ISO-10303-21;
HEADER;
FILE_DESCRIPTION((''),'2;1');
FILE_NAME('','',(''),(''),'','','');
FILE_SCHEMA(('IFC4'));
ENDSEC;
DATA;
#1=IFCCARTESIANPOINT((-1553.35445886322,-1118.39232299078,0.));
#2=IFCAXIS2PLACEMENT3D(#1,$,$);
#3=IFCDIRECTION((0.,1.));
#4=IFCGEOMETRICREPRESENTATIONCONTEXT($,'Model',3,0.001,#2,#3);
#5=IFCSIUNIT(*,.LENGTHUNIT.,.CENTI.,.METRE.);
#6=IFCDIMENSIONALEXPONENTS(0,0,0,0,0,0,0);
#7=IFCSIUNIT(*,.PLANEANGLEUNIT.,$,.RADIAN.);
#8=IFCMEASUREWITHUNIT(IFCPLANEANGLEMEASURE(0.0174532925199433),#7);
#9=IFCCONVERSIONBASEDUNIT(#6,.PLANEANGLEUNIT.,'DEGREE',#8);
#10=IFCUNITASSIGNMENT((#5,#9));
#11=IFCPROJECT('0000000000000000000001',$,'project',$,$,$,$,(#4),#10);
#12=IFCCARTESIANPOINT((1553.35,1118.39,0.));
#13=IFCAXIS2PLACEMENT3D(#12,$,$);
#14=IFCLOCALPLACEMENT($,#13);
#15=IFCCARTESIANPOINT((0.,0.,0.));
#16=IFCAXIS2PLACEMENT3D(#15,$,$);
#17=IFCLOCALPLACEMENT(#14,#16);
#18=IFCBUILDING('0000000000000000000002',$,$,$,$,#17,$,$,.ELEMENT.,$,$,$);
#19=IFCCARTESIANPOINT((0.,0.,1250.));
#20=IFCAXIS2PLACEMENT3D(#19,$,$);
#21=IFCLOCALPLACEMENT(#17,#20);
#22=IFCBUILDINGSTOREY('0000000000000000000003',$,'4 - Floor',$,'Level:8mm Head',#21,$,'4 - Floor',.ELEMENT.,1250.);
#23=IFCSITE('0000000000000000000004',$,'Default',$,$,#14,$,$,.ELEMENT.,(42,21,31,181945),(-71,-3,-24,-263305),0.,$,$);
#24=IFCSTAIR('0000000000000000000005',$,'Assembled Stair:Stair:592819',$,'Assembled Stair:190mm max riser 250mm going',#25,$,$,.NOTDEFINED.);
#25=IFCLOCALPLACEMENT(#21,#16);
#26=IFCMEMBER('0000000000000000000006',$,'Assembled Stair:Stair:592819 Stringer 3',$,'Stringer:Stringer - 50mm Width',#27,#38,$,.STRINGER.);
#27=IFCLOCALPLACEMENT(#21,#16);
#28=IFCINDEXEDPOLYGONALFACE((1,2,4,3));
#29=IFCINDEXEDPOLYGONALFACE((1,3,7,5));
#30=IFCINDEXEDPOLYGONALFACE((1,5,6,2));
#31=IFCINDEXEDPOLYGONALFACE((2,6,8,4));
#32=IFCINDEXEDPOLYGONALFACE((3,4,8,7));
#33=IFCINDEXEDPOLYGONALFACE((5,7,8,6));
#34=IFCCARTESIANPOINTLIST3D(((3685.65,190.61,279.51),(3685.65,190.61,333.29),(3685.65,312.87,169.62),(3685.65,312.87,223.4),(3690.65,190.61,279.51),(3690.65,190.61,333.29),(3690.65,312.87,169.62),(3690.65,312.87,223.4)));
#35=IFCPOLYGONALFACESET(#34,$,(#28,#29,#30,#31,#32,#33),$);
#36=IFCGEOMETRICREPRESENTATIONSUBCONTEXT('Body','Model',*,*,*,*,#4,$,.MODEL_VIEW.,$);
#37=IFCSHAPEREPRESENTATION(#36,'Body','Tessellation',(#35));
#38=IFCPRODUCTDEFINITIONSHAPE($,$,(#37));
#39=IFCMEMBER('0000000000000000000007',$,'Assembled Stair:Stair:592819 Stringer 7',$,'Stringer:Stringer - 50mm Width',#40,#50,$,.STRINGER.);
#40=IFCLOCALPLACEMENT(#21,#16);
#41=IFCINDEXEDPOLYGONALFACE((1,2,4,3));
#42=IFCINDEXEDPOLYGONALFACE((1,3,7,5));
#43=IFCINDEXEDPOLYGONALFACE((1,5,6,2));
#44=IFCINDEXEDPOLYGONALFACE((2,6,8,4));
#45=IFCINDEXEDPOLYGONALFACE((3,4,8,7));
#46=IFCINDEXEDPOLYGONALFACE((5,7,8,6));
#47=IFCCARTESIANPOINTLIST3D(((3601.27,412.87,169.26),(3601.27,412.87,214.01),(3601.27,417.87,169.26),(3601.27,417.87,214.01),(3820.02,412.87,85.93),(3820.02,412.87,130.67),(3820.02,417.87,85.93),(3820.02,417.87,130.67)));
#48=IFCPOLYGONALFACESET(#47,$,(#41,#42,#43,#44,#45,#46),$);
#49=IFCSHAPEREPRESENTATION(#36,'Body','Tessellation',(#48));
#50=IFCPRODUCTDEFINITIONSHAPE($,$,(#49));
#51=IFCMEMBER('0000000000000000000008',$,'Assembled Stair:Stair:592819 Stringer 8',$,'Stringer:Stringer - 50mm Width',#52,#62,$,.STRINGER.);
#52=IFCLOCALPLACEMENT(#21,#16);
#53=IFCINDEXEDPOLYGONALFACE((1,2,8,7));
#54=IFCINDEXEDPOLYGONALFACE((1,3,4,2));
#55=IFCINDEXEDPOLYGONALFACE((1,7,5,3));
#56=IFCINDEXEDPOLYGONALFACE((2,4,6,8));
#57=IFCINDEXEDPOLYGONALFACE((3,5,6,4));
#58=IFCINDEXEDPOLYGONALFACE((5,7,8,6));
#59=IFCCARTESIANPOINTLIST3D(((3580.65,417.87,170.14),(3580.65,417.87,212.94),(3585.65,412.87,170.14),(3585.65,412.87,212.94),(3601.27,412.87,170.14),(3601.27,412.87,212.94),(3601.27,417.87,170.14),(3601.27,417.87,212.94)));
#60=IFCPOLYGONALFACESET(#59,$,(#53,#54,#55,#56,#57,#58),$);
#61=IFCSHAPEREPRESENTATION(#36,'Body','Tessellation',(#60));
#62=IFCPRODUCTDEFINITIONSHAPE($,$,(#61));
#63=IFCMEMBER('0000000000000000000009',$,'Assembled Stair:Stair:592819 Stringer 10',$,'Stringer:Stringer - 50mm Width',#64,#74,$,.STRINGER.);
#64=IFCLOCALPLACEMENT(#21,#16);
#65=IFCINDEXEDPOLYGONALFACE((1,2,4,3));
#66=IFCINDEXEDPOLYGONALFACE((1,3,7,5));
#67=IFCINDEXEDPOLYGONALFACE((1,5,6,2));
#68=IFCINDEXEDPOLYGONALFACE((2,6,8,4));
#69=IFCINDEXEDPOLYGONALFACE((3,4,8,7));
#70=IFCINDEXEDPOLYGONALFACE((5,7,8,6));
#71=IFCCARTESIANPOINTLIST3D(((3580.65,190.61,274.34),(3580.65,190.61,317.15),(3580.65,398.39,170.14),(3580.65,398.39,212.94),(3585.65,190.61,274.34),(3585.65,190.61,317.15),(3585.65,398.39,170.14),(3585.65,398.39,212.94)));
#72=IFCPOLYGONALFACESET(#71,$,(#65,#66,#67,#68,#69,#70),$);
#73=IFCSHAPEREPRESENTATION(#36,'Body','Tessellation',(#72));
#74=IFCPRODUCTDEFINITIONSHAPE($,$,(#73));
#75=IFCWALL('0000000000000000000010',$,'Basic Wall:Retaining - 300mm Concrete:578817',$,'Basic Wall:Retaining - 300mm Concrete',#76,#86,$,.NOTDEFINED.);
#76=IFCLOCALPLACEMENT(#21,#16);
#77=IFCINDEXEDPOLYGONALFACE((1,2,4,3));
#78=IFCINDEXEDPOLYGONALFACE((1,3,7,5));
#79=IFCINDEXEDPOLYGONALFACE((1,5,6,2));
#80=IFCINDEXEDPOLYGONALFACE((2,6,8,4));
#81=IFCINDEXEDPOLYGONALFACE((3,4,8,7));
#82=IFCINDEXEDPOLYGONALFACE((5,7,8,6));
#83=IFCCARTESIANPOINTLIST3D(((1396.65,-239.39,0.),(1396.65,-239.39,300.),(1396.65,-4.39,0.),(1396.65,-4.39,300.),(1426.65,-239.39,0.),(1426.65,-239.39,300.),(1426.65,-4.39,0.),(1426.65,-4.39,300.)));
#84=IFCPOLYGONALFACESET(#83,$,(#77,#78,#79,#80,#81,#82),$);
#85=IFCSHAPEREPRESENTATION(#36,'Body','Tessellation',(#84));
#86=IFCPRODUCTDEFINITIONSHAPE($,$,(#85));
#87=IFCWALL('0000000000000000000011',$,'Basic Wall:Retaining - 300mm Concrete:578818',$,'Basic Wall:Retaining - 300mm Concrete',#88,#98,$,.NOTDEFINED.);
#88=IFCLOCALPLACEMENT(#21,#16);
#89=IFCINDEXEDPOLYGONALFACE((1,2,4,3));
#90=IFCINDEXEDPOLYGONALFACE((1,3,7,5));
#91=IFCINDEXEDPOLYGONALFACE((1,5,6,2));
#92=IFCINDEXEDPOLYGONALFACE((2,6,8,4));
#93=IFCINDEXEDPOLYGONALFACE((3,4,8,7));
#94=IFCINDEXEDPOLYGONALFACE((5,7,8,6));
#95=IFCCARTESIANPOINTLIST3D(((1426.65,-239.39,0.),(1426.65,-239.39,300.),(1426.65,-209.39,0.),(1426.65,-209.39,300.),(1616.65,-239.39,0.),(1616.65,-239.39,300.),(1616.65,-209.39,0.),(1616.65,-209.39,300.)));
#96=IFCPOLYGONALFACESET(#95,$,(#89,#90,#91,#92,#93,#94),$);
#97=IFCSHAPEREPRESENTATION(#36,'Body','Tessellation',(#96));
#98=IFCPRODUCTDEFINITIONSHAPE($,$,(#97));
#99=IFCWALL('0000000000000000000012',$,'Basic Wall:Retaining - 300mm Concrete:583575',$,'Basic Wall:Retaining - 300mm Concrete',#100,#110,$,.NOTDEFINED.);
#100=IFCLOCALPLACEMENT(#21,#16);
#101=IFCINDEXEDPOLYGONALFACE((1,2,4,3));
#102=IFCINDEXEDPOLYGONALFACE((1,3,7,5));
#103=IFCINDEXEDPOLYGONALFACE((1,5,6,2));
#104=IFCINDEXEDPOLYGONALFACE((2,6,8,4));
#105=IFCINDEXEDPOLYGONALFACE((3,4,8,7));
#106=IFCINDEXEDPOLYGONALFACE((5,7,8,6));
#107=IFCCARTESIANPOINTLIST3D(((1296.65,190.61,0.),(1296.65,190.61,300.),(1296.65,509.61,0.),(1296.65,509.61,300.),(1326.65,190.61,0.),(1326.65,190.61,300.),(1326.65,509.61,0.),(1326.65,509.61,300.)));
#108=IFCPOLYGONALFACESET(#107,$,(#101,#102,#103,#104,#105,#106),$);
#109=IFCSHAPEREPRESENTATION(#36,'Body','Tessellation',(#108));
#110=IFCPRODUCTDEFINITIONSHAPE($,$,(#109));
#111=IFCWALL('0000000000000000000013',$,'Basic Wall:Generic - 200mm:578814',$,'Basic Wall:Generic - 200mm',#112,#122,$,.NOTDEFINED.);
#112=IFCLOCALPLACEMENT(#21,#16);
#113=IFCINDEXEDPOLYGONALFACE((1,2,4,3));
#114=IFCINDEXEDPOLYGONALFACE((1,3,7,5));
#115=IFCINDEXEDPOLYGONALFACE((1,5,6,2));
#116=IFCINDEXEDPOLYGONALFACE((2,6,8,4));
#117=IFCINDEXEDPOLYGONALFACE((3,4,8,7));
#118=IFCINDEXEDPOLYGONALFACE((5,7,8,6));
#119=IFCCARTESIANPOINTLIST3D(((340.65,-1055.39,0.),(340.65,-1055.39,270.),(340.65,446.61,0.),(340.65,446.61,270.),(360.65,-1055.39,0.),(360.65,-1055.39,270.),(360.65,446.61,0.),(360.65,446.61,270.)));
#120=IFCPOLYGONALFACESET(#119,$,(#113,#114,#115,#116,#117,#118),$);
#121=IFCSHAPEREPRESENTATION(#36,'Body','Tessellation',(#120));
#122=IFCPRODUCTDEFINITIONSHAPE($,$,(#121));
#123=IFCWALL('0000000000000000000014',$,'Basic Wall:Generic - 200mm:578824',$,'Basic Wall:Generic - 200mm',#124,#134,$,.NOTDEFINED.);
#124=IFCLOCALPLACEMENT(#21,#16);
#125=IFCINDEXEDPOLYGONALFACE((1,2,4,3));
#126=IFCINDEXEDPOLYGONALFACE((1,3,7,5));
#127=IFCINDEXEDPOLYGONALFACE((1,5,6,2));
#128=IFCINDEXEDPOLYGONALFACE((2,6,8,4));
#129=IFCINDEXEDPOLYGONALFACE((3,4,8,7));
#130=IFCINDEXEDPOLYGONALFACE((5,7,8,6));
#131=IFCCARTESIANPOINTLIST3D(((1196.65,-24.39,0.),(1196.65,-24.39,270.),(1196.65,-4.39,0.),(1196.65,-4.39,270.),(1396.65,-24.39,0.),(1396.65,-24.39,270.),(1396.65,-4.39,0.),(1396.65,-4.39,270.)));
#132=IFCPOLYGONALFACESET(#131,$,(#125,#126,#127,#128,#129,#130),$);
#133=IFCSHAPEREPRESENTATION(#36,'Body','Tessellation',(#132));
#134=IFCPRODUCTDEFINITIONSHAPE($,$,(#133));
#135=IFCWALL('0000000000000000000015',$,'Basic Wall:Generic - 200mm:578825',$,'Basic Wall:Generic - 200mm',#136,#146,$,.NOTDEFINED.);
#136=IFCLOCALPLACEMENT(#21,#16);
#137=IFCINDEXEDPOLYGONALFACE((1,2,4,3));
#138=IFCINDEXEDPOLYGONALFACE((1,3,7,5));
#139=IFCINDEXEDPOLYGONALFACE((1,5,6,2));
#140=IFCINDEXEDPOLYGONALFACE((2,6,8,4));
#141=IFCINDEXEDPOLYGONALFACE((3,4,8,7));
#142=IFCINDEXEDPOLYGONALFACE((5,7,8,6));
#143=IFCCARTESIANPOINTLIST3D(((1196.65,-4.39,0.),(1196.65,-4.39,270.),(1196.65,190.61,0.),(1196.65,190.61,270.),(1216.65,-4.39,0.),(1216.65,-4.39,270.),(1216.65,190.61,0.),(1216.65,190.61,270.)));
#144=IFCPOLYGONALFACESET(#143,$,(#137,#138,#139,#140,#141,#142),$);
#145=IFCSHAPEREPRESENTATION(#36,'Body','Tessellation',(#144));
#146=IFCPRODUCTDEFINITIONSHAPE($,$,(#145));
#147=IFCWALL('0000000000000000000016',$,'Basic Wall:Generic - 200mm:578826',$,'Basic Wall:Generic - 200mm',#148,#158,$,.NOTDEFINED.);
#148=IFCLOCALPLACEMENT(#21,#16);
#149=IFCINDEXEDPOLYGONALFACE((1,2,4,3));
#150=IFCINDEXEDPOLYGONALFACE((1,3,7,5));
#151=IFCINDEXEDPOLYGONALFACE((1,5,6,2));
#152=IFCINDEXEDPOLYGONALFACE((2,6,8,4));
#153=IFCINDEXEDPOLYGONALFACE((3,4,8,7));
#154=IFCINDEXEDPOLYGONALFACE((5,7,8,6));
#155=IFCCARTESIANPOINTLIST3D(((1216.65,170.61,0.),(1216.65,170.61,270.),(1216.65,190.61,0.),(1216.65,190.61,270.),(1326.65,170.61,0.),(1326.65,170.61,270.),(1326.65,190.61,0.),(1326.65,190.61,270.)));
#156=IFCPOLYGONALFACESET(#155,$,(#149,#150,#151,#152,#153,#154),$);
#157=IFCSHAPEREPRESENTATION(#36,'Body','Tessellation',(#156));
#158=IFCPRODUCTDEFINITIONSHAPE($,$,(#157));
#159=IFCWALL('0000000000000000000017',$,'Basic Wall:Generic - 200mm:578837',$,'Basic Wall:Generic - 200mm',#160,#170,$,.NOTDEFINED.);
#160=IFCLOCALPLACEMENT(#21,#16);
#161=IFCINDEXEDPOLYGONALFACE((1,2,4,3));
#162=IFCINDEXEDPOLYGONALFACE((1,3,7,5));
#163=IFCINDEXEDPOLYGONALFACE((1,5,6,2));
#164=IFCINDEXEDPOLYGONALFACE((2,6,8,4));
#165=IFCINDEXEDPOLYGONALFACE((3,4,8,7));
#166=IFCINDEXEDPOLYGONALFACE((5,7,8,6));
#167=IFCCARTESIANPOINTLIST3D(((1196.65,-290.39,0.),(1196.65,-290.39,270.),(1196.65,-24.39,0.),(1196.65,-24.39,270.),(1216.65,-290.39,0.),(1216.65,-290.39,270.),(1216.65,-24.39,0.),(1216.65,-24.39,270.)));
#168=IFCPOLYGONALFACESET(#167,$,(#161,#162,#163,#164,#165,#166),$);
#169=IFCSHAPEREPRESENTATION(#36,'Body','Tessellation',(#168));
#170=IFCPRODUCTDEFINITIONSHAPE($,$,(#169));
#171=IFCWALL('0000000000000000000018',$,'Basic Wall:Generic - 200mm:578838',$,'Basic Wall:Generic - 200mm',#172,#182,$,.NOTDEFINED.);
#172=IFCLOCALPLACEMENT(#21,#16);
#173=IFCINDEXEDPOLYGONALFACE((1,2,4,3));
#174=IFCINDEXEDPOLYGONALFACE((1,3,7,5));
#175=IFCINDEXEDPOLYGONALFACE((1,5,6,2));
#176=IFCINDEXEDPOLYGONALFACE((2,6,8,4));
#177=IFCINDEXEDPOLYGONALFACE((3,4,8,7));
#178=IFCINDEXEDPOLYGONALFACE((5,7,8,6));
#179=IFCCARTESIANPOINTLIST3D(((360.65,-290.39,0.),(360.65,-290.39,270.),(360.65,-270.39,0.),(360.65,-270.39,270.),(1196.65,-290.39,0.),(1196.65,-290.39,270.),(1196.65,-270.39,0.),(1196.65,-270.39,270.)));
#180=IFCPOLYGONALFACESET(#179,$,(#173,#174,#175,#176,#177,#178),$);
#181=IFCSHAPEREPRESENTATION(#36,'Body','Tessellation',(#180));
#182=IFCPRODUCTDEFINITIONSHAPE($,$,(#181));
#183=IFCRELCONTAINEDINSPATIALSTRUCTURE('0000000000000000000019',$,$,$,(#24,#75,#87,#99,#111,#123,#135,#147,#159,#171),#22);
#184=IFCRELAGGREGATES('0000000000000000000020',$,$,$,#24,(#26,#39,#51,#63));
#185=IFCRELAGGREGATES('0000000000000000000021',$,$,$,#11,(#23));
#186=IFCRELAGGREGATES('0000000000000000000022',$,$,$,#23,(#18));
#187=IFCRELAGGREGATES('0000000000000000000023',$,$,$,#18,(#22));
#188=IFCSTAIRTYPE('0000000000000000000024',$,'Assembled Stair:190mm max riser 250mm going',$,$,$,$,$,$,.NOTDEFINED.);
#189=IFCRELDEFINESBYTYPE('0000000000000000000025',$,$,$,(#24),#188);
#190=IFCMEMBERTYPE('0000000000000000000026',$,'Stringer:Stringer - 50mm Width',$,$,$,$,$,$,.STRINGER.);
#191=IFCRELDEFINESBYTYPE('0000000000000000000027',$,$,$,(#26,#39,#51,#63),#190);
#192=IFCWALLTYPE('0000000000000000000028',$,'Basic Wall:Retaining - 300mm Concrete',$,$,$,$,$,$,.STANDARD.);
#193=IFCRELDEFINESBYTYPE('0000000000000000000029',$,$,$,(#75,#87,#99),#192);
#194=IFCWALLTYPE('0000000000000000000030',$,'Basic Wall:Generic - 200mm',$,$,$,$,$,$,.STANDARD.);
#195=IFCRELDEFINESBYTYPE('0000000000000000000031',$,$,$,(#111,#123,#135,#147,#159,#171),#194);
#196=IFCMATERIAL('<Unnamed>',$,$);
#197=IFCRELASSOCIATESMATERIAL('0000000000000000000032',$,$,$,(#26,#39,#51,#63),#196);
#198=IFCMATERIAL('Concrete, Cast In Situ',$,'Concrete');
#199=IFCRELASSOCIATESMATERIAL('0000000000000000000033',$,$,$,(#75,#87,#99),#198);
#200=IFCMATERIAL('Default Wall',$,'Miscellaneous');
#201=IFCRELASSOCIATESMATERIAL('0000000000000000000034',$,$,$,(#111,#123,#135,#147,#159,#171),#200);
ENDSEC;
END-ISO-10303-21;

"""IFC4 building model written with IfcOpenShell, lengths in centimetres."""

from ifc_helpers import new_model, entity, si_unit, converted_unit, direction, frame, origin, place, context, subcontext, project, spatial, indexed_curve, outline, extrude, material, type_object, element, aggregate, save


model = new_model("IFC4")

# Units and contexts
model_context = context("Model", 3, precision=0.001, world=frame((-1553.35445886322, -1118.39232299078, 0.0)), true_north=direction((0.0, 1.0)))
body_context = subcontext(model_context, "Body", "Model", "MODEL_VIEW")
ifc_project = project(units=[si_unit("LENGTHUNIT", "METRE", prefix="CENTI"), converted_unit("PLANEANGLEUNIT", "DEGREE", entity("IfcPlaneAngleMeasure", 0.0174532925199433), si_unit("PLANEANGLEUNIT", "RADIAN"), dimensions=[0, 0, 0, 0, 0, 0, 0])], contexts=[model_context])

# Site, building, storey
site_placement = place(None, frame((1553.35, 1118.39, 0.0)))
site = spatial("IfcSite", under=ifc_project, at=site_placement, Name="Default", CompositionType="ELEMENT", RefLatitude=(42, 21, 31, 181945), RefLongitude=(-71, -3, -24, -263305), RefElevation=0.0)
building_placement = place(site_placement, origin())
building = spatial("IfcBuilding", under=site, at=building_placement, CompositionType="ELEMENT")
storey_placement = place(building_placement, frame((0.0, 0.0, 1250.0)))
storey = spatial("IfcBuildingStorey", under=building, at=storey_placement, Name="4 - Floor", ObjectType="Level:8mm Head", LongName="4 - Floor", CompositionType="ELEMENT", Elevation=1250.0)

# Stair, members
stair_type = type_object("IfcStairType", Name="Assembled Stair:190mm max riser 250mm going", PredefinedType="NOTDEFINED")
stair_placement = place(storey_placement, origin())
stair = element("IfcStair", 1, at=stair_placement, inside=storey, type_object=stair_type, Name="Assembled Stair:Stair:592819", ObjectType="Assembled Stair:190mm max riser 250mm going", PredefinedType="NOTDEFINED")
ifc_material_1 = material(Name="<Unnamed>")
member_type = type_object("IfcMemberType", Name="Stringer:Stringer - 50mm Width", PredefinedType="STRINGER")
member_1_placement = place(stair_placement, origin())
member_1 = element("IfcMember", 2, at=member_1_placement, type_object=member_type, material=ifc_material_1, Name="Assembled Stair:Stair:592819 Stringer 3", ObjectType="Stringer:Stringer - 50mm Width", PredefinedType="STRINGER", context=body_context, shape_type="SweptSolid", body=[
    extrude(outline(indexed_curve([(-64.22, -20.0), (100.17, -20.0), (64.22, 20.0), (-100.17, 20.0), (-64.22, -20.0)], self_intersect=False)), frame((3685.65, 251.74, 251.46), z_axis=(1.0, 0.0, 0.0), x_axis=(0.0, -0.74373, 0.668481)), (0.0, 0.0, 1.0), 5.0),
])
member_2_placement = place(stair_placement, origin())
member_2 = element("IfcMember", 3, at=member_2_placement, type_object=member_type, material=ifc_material_1, Name="Assembled Stair:Stair:592819 Stringer 7", ObjectType="Stringer:Stringer - 50mm Width", PredefinedType="STRINGER", context=body_context, shape_type="SweptSolid", body=[
    extrude(outline(indexed_curve([(-125.01, -20.91), (109.08, -20.91), (125.01, 20.91), (-109.08, 20.91), (-125.01, -20.91)], self_intersect=False)), frame((3710.65, 412.87, 149.97), z_axis=(0.0, 1.0, 0.0), x_axis=(-0.934489, 0.0, 0.355992)), (0.0, 0.0, 1.0), 5.0),
])
member_3_placement = place(stair_placement, origin())
member_3 = element("IfcMember", 4, at=member_3_placement, type_object=member_type, material=ifc_material_1, Name="Assembled Stair:Stair:592819 Stringer 8", ObjectType="Stringer:Stringer - 50mm Width", PredefinedType="STRINGER", context=body_context, shape_type="SweptSolid", body=[
    extrude(outline(indexed_curve([(-9.06, -2.5), (11.56, -2.5), (6.56, 2.5), (-9.06, 2.5), (-9.06, -2.5)], self_intersect=False)), frame((3592.21, 415.37, 170.14), z_axis=(0.0, 0.0, 1.0), x_axis=(-1.0, 0.0, 0.0)), (0.0, 0.0, 1.0), 42.8),
])
member_4_placement = place(stair_placement, origin())
member_4 = element("IfcMember", 5, at=member_4_placement, type_object=member_type, material=ifc_material_1, Name="Assembled Stair:Stair:592819 Stringer 10", ObjectType="Stringer:Stringer - 50mm Width", PredefinedType="STRINGER", context=body_context, shape_type="SweptSolid", body=[
    extrude(outline(indexed_curve([(-106.63, -19.13), (125.82, -19.13), (106.63, 19.13), (-125.82, 19.13), (-106.63, -19.13)], self_intersect=False)), frame((3580.65, 294.5, 243.64), z_axis=(1.0, 0.0, 0.0), x_axis=(0.0, -0.893886, 0.448294)), (0.0, 0.0, 1.0), 5.0),
])
aggregate(stair, [member_1, member_2, member_3, member_4])

# Walls
ifc_material_2 = material(Name="Concrete, Cast In Situ", Category="Concrete")
wall_type_1 = type_object("IfcWallType", Name="Basic Wall:Retaining - 300mm Concrete", PredefinedType="STANDARD")
wall_1_placement = place(storey_placement, frame((1411.65, -4.39, 0.0), z_axis=(0.0, 0.0, 1.0), x_axis=(0.0, -1.0, 0.0)))
element("IfcWall", 6, at=wall_1_placement, inside=storey, type_object=wall_type_1, material=ifc_material_2, Name="Basic Wall:Retaining - 300mm Concrete:578817", ObjectType="Basic Wall:Retaining - 300mm Concrete", PredefinedType="NOTDEFINED", context=body_context, shape_type="SweptSolid", body=[
    extrude(outline(indexed_curve([(235.0, 15.0), (0.0, 15.0), (0.0, -15.0), (235.0, -15.0), (235.0, 15.0)], self_intersect=False)), origin(), (0.0, 0.0, 1.0), 300.0),
])
wall_2_placement = place(storey_placement, frame((1426.65, -224.39, 0.0)))
element("IfcWall", 7, at=wall_2_placement, inside=storey, type_object=wall_type_1, material=ifc_material_2, Name="Basic Wall:Retaining - 300mm Concrete:578818", ObjectType="Basic Wall:Retaining - 300mm Concrete", PredefinedType="NOTDEFINED", context=body_context, shape_type="SweptSolid", body=[
    extrude(outline(indexed_curve([(190.0, 15.0), (0.0, 15.0), (0.0, -15.0), (190.0, -15.0), (190.0, 15.0)], self_intersect=False)), origin(), (0.0, 0.0, 1.0), 300.0),
])
wall_3_placement = place(storey_placement, frame((1311.65, 509.61, 0.0), z_axis=(0.0, 0.0, 1.0), x_axis=(0.0, -1.0, 0.0)))
element("IfcWall", 8, at=wall_3_placement, inside=storey, type_object=wall_type_1, material=ifc_material_2, Name="Basic Wall:Retaining - 300mm Concrete:583575", ObjectType="Basic Wall:Retaining - 300mm Concrete", PredefinedType="NOTDEFINED", context=body_context, shape_type="SweptSolid", body=[
    extrude(outline(indexed_curve([(319.0, 15.0), (0.0, 15.0), (0.0, -15.0), (319.0, -15.0), (319.0, 15.0)], self_intersect=False)), origin(), (0.0, 0.0, 1.0), 300.0),
])
ifc_material_3 = material(Name="Default Wall", Category="Miscellaneous")
wall_type_2 = type_object("IfcWallType", Name="Basic Wall:Generic - 200mm", PredefinedType="STANDARD")
wall_4_placement = place(storey_placement, frame((350.65, 446.61, 0.0), z_axis=(0.0, 0.0, 1.0), x_axis=(0.0, -1.0, 0.0)))
element("IfcWall", 9, at=wall_4_placement, inside=storey, type_object=wall_type_2, material=ifc_material_3, Name="Basic Wall:Generic - 200mm:578814", ObjectType="Basic Wall:Generic - 200mm", PredefinedType="NOTDEFINED", context=body_context, shape_type="SweptSolid", body=[
    extrude(outline(indexed_curve([(1502.0, 10.0), (0.0, 10.0), (0.0, -10.0), (1502.0, -10.0), (1502.0, 10.0)], self_intersect=False)), origin(), (0.0, 0.0, 1.0), 270.0),
])
wall_5_placement = place(storey_placement, frame((1396.65, -14.39, 0.0), z_axis=(0.0, 0.0, 1.0), x_axis=(-1.0, 0.0, 0.0)))
element("IfcWall", 10, at=wall_5_placement, inside=storey, type_object=wall_type_2, material=ifc_material_3, Name="Basic Wall:Generic - 200mm:578824", ObjectType="Basic Wall:Generic - 200mm", PredefinedType="NOTDEFINED", context=body_context, shape_type="SweptSolid", body=[
    extrude(outline(indexed_curve([(200.0, 10.0), (0.0, 10.0), (0.0, -10.0), (200.0, -10.0), (200.0, 10.0)], self_intersect=False)), origin(), (0.0, 0.0, 1.0), 270.0),
])
wall_6_placement = place(storey_placement, frame((1206.65, -4.39, 0.0), z_axis=(0.0, 0.0, 1.0), x_axis=(0.0, 1.0, 0.0)))
element("IfcWall", 11, at=wall_6_placement, inside=storey, type_object=wall_type_2, material=ifc_material_3, Name="Basic Wall:Generic - 200mm:578825", ObjectType="Basic Wall:Generic - 200mm", PredefinedType="NOTDEFINED", context=body_context, shape_type="SweptSolid", body=[
    extrude(outline(indexed_curve([(195.0, 10.0), (0.0, 10.0), (0.0, -10.0), (195.0, -10.0), (195.0, 10.0)], self_intersect=False)), origin(), (0.0, 0.0, 1.0), 270.0),
])
wall_7_placement = place(storey_placement, frame((1216.65, 180.61, 0.0)))
element("IfcWall", 12, at=wall_7_placement, inside=storey, type_object=wall_type_2, material=ifc_material_3, Name="Basic Wall:Generic - 200mm:578826", ObjectType="Basic Wall:Generic - 200mm", PredefinedType="NOTDEFINED", context=body_context, shape_type="SweptSolid", body=[
    extrude(outline(indexed_curve([(110.0, 10.0), (0.0, 10.0), (0.0, -10.0), (110.0, -10.0), (110.0, 10.0)], self_intersect=False)), origin(), (0.0, 0.0, 1.0), 270.0),
])
wall_8_placement = place(storey_placement, frame((1206.65, -24.39, 0.0), z_axis=(0.0, 0.0, 1.0), x_axis=(0.0, -1.0, 0.0)))
element("IfcWall", 13, at=wall_8_placement, inside=storey, type_object=wall_type_2, material=ifc_material_3, Name="Basic Wall:Generic - 200mm:578837", ObjectType="Basic Wall:Generic - 200mm", PredefinedType="NOTDEFINED", context=body_context, shape_type="SweptSolid", body=[
    extrude(outline(indexed_curve([(266.0, 10.0), (0.0, 10.0), (0.0, -10.0), (266.0, -10.0), (266.0, 10.0)], self_intersect=False)), origin(), (0.0, 0.0, 1.0), 270.0),
])
wall_9_placement = place(storey_placement, frame((1196.65, -280.39, 0.0), z_axis=(0.0, 0.0, 1.0), x_axis=(-1.0, 0.0, 0.0)))
element("IfcWall", 14, at=wall_9_placement, inside=storey, type_object=wall_type_2, material=ifc_material_3, Name="Basic Wall:Generic - 200mm:578838", ObjectType="Basic Wall:Generic - 200mm", PredefinedType="NOTDEFINED", context=body_context, shape_type="SweptSolid", body=[
    extrude(outline(indexed_curve([(836.0, 10.0), (0.0, 10.0), (0.0, -10.0), (836.0, -10.0), (836.0, 10.0)], self_intersect=False)), origin(), (0.0, 0.0, 1.0), 270.0),
])

save(model, "model.ifc")
